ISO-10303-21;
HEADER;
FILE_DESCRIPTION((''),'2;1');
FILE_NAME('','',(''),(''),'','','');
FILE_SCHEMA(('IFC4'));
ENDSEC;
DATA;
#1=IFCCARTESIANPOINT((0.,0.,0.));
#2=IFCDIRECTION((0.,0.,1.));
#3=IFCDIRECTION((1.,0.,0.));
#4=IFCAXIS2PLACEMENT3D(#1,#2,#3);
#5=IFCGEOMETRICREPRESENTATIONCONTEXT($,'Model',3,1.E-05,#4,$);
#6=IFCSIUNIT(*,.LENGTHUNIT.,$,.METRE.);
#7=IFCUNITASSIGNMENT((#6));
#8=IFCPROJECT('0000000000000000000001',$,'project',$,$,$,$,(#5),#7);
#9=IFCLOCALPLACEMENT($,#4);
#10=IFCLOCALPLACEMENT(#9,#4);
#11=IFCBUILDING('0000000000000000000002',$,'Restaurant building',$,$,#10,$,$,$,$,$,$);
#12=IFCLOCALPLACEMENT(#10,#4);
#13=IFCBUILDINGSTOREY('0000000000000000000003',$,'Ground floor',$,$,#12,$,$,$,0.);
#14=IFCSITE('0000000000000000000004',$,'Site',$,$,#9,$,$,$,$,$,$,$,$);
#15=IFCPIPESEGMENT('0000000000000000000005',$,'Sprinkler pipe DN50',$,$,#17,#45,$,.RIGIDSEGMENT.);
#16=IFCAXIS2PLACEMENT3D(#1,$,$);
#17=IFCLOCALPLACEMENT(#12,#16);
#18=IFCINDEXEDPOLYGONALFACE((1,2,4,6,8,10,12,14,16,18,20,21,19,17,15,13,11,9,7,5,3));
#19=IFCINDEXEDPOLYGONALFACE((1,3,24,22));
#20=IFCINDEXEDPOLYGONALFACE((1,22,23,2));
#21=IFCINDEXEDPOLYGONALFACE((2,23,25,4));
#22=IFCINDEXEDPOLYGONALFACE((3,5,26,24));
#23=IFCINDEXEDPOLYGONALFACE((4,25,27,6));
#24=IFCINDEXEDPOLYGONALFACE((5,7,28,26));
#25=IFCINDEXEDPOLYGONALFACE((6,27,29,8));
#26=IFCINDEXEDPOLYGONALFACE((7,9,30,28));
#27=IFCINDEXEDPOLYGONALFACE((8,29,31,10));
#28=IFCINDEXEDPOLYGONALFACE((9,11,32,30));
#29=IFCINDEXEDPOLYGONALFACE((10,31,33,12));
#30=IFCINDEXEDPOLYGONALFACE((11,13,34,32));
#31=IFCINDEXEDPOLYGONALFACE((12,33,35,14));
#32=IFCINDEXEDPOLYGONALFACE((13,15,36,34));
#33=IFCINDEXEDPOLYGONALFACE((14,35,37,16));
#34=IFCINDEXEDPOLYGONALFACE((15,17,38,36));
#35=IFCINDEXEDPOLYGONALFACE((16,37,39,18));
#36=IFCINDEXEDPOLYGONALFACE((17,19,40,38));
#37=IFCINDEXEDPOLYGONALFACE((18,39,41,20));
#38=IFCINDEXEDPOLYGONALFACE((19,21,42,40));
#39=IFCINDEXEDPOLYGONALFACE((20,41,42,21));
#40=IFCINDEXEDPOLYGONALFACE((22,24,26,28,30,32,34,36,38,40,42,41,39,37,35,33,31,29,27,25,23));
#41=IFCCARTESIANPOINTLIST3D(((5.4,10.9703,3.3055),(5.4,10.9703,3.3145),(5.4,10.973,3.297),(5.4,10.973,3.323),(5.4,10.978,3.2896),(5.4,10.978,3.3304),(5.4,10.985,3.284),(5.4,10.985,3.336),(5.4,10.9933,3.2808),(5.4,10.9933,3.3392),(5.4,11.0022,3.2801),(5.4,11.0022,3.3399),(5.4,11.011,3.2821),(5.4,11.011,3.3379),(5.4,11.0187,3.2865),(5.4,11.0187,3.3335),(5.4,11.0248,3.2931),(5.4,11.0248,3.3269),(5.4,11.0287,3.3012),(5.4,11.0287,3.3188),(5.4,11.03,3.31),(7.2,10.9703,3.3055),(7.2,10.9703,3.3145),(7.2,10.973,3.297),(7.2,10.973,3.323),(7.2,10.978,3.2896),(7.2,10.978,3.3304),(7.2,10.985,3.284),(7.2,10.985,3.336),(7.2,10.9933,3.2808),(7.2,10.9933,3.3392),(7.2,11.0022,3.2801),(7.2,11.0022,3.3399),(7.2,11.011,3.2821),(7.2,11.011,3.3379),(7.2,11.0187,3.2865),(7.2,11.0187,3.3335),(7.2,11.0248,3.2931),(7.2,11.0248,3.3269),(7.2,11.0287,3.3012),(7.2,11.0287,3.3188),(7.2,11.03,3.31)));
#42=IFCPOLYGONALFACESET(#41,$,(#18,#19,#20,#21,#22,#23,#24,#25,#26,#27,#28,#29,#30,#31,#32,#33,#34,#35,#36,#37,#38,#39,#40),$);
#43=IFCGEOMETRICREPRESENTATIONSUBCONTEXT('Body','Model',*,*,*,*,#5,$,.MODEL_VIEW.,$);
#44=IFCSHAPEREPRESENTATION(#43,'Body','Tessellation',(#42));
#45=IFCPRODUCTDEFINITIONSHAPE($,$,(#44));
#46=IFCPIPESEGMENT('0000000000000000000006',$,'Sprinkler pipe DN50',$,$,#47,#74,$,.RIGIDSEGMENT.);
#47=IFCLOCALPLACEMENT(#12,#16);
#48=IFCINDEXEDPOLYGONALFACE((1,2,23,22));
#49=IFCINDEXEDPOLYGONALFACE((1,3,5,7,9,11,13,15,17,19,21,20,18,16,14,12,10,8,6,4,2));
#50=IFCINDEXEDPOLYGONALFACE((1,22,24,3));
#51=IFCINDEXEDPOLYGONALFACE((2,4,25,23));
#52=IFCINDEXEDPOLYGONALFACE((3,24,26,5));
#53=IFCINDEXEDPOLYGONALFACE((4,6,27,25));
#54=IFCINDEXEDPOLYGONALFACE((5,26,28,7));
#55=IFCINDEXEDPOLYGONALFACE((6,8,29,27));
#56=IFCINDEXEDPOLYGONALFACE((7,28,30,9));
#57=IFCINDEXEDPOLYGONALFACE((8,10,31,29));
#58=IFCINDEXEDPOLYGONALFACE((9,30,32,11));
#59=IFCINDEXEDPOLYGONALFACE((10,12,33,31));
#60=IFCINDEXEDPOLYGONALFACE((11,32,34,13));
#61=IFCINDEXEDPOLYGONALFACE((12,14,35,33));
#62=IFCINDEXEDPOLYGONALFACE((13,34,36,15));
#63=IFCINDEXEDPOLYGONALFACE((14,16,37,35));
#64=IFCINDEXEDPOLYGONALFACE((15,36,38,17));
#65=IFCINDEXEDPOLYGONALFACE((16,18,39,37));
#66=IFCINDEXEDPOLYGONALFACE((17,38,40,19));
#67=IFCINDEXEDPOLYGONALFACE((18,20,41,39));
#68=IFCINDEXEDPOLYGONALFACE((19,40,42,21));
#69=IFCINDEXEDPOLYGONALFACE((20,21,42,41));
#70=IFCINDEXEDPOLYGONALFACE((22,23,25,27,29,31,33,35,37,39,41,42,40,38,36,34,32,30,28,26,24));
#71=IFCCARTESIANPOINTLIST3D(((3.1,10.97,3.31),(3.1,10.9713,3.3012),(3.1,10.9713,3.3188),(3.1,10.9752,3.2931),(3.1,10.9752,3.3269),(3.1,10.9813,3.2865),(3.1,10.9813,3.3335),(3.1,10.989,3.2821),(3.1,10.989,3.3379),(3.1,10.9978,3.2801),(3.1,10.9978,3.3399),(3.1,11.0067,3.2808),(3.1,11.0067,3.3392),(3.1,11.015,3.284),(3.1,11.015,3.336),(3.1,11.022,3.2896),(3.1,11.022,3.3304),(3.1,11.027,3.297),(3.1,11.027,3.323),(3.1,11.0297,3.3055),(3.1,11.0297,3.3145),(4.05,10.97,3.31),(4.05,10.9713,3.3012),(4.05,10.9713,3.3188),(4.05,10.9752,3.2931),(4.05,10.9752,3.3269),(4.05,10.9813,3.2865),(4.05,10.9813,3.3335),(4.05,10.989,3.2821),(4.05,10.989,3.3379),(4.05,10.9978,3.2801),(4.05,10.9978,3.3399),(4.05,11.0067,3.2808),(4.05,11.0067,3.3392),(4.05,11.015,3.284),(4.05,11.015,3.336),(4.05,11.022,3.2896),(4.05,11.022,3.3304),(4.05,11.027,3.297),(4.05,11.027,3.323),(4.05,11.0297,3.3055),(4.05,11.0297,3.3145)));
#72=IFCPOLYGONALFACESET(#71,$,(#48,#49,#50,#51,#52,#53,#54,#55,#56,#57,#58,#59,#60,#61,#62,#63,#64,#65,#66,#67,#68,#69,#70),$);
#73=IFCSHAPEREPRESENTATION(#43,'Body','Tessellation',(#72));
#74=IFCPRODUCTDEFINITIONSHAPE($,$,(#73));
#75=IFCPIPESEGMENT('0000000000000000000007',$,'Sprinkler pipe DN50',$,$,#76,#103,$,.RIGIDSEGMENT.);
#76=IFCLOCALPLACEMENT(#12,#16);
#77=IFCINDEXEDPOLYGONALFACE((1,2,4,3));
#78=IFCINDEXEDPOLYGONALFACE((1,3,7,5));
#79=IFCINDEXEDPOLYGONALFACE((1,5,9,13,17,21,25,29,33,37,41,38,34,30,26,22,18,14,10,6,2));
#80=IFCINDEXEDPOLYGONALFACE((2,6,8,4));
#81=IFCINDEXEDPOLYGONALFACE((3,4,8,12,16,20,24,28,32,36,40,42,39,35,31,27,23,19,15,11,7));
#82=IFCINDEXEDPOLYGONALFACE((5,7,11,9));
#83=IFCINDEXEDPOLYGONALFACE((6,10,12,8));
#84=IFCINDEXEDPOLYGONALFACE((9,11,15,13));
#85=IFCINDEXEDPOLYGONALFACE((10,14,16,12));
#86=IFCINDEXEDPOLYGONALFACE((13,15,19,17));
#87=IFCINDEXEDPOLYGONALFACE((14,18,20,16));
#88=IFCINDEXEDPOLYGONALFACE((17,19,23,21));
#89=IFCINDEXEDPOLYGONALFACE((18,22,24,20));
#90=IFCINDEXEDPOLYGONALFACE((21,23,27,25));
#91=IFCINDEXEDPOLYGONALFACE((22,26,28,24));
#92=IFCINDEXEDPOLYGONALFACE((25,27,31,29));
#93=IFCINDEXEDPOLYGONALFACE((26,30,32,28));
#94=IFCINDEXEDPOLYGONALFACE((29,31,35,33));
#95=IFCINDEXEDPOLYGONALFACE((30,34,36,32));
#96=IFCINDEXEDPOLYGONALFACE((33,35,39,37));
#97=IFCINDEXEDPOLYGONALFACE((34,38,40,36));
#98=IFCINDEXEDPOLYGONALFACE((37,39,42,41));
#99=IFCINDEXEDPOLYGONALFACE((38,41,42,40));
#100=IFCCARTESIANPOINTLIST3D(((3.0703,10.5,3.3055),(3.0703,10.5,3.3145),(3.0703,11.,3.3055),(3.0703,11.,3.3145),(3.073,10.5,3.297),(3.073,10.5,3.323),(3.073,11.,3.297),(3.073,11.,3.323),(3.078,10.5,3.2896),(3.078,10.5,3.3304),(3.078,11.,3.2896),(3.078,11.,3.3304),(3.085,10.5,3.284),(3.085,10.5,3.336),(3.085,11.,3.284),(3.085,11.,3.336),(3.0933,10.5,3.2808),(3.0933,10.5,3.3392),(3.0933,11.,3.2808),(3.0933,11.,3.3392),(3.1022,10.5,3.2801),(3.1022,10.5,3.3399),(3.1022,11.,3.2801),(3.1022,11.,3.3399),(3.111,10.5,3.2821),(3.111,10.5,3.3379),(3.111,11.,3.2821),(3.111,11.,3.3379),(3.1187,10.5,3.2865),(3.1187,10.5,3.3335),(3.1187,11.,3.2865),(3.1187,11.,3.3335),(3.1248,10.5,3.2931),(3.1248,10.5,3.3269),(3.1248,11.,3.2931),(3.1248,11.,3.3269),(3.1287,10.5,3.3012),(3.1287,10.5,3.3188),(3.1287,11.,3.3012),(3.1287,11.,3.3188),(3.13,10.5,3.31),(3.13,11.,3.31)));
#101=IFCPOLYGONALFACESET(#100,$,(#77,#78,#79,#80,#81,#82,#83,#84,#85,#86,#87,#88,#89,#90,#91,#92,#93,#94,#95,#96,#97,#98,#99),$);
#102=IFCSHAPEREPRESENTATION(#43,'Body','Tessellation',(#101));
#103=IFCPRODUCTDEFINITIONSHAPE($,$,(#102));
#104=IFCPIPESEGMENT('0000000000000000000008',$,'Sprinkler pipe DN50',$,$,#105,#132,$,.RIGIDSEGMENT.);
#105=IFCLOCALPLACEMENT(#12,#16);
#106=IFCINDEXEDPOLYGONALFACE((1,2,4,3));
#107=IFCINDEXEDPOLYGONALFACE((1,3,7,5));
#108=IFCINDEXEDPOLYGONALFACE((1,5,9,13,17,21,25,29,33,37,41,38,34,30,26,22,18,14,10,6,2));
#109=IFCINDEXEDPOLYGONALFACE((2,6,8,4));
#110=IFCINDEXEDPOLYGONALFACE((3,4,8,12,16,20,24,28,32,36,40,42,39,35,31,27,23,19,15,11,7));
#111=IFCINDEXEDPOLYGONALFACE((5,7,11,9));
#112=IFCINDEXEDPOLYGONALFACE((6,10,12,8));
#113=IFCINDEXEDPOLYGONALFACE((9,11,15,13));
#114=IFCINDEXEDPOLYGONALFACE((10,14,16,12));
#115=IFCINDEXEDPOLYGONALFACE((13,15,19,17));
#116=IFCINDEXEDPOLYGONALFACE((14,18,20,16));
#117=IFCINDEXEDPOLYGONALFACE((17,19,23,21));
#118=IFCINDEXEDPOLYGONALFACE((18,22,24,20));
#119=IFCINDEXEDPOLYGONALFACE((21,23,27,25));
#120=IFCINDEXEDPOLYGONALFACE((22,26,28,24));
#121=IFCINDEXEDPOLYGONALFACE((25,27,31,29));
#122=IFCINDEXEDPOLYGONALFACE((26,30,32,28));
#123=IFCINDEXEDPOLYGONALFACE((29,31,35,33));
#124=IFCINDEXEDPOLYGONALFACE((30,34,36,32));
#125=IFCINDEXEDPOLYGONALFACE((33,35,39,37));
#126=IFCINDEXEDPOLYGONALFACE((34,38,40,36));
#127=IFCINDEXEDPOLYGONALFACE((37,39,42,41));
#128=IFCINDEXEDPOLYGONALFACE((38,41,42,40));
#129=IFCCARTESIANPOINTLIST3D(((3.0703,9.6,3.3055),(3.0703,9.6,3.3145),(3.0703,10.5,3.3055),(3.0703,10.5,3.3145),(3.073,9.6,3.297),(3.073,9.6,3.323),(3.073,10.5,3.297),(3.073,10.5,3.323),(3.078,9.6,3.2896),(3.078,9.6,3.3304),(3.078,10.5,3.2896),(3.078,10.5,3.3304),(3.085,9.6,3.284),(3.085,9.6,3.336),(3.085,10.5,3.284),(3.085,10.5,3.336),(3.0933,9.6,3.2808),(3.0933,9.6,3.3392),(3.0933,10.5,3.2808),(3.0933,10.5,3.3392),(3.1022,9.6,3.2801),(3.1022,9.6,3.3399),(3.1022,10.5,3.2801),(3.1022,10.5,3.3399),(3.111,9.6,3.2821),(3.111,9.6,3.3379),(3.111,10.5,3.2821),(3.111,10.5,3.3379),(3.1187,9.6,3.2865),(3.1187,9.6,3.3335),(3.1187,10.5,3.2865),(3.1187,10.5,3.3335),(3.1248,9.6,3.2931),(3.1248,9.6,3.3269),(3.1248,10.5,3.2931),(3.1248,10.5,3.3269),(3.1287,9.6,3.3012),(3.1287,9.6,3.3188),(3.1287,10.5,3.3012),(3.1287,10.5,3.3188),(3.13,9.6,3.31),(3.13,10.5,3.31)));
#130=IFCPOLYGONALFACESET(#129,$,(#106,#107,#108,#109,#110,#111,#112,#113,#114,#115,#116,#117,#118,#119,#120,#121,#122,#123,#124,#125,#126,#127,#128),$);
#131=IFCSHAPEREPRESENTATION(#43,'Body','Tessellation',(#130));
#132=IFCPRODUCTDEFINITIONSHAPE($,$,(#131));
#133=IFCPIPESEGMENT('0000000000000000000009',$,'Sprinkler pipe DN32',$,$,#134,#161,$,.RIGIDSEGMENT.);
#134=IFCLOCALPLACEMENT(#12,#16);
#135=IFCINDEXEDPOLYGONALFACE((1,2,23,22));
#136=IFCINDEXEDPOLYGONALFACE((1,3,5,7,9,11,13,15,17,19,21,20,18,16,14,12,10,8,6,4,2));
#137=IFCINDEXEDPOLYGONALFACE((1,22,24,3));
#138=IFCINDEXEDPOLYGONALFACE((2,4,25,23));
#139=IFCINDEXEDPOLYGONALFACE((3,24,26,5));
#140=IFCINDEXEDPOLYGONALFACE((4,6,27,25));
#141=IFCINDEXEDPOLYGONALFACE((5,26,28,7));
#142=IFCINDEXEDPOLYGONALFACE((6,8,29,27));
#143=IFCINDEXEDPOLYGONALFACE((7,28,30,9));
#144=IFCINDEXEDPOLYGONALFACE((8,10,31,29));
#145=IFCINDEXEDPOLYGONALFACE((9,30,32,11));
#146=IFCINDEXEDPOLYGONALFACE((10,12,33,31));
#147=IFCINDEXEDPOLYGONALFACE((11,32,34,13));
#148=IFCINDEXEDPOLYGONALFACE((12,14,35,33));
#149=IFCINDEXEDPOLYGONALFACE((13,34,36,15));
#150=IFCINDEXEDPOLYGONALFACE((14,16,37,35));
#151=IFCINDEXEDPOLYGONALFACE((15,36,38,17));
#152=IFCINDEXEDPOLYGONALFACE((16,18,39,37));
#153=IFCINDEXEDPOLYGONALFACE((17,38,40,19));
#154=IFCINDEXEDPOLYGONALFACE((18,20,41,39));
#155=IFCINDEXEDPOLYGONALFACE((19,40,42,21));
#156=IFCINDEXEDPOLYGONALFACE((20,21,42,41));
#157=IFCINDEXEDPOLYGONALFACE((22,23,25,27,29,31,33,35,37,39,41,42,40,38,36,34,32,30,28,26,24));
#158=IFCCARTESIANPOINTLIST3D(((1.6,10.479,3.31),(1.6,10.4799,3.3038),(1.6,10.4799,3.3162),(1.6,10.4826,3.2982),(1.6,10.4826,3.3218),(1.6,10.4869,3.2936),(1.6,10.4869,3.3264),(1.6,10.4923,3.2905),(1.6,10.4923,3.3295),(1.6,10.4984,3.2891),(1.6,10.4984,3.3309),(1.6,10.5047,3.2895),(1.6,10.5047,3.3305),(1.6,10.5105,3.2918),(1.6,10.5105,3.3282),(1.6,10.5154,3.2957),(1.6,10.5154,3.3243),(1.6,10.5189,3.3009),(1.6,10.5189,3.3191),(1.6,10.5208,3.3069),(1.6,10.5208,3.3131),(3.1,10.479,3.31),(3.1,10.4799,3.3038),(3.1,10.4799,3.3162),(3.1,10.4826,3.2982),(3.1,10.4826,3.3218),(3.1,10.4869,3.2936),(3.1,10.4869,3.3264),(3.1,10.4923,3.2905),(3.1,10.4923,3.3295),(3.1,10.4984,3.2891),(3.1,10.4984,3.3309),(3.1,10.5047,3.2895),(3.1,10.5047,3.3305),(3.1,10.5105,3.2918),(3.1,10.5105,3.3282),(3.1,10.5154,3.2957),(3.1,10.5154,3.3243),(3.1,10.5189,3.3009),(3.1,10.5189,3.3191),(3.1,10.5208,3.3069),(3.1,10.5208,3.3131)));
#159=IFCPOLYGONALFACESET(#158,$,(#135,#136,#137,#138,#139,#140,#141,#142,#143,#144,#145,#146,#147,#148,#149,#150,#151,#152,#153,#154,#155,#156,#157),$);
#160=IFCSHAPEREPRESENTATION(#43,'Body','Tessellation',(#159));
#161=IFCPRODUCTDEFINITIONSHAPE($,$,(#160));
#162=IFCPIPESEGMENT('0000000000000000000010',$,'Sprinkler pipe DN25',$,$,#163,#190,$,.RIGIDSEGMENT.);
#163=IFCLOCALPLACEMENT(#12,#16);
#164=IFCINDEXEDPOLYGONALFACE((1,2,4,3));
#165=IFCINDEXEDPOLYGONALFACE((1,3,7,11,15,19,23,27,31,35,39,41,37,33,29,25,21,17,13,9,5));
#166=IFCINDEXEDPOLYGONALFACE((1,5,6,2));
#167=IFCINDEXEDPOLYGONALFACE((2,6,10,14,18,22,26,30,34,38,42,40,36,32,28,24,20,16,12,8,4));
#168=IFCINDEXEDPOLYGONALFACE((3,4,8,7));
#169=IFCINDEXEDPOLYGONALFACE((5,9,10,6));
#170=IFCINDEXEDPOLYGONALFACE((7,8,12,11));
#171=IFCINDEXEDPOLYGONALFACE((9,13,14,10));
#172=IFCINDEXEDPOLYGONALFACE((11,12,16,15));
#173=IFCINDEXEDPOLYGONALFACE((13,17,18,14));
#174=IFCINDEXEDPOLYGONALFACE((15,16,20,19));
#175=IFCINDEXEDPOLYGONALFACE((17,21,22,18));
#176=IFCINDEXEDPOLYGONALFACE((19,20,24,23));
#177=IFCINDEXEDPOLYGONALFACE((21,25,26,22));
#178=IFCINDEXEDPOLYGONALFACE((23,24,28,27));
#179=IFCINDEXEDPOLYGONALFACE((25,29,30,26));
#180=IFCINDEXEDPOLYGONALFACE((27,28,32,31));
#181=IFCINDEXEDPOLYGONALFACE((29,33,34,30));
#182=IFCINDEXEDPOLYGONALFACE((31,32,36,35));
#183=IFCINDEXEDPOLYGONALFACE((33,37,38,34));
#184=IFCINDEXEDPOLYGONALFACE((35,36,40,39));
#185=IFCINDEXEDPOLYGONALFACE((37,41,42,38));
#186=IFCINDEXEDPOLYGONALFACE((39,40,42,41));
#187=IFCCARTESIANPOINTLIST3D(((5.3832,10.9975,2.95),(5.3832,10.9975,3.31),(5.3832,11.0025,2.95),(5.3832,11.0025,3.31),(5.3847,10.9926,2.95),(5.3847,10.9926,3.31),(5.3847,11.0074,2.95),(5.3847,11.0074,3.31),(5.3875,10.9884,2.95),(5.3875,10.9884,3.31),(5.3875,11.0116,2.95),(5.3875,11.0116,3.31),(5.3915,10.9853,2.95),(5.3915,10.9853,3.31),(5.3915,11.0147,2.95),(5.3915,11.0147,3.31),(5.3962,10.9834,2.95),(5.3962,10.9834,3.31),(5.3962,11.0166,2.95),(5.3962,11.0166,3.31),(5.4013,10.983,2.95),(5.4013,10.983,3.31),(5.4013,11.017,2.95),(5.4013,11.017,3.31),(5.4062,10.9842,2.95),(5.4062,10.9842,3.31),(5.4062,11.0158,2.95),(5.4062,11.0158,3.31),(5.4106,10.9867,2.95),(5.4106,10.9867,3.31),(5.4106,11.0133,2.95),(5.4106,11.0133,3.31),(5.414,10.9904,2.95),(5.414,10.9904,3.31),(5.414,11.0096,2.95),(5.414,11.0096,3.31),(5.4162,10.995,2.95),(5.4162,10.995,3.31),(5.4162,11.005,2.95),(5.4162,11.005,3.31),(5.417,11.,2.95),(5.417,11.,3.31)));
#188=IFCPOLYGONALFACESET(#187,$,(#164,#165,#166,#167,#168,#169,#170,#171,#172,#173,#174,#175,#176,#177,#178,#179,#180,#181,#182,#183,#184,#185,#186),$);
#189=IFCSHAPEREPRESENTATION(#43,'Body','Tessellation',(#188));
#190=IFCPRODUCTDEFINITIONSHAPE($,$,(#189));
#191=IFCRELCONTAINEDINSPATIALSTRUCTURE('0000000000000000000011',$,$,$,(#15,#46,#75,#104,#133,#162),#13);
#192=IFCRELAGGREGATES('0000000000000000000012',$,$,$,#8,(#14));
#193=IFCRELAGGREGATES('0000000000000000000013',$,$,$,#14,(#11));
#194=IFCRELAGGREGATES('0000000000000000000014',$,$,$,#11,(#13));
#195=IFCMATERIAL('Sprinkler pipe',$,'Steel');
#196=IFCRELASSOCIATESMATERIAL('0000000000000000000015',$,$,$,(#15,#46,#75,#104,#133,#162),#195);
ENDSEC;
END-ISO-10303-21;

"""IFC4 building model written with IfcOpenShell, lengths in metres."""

from ifc_helpers import new_model, si_unit, frame, origin_with_axes, origin_2d, place, context, subcontext, project, spatial, circle, extrude, material, element, save


model = new_model("IFC4")

# Units and contexts
model_context = context("Model", 3, precision=1e-05, world=origin_with_axes())
body_context = subcontext(model_context, "Body", "Model", "MODEL_VIEW")
ifc_project = project(units=[si_unit("LENGTHUNIT", "METRE")], contexts=[model_context])

# Site, building, storey
site_placement = place(None, origin_with_axes())
site = spatial("IfcSite", under=ifc_project, at=site_placement, Name="Site")
building_placement = place(site_placement, origin_with_axes())
building = spatial("IfcBuilding", under=site, at=building_placement, Name="Restaurant building")
storey_placement = place(building_placement, origin_with_axes())
storey = spatial("IfcBuildingStorey", under=building, at=storey_placement, Name="Ground floor", Elevation=0.0)

# Pipe segments
ifc_material_1 = material(Name="Sprinkler pipe", Category="Steel")
pipe_segment_1_placement = place(storey_placement, frame((5.4, 11.0, 3.31)))
element("IfcPipeSegment", 1, at=pipe_segment_1_placement, inside=storey, material=ifc_material_1, Name="Sprinkler pipe DN50", PredefinedType="RIGIDSEGMENT", context=body_context, shape_type="SweptSolid", body=[
    extrude(circle(Radius=0.03, at=origin_2d()), frame((0.0, 0.0, 0.0), z_axis=(1.0, 0.0, 0.0), x_axis=(0.0, 1.0, 0.0)), (0.0, 0.0, 1.0), 1.8),
])
pipe_segment_2_placement = place(storey_placement, frame((4.05, 11.0, 3.31)))
element("IfcPipeSegment", 2, at=pipe_segment_2_placement, inside=storey, material=ifc_material_1, Name="Sprinkler pipe DN50", PredefinedType="RIGIDSEGMENT", context=body_context, shape_type="SweptSolid", body=[
    extrude(circle(Radius=0.03, at=origin_2d()), frame((0.0, 0.0, 0.0), z_axis=(-1.0, 0.0, 0.0), x_axis=(0.0, -1.0, 0.0)), (0.0, 0.0, 1.0), 0.95),
])
pipe_segment_3_placement = place(storey_placement, frame((3.1, 11.0, 3.31)))
element("IfcPipeSegment", 3, at=pipe_segment_3_placement, inside=storey, material=ifc_material_1, Name="Sprinkler pipe DN50", PredefinedType="RIGIDSEGMENT", context=body_context, shape_type="SweptSolid", body=[
    extrude(circle(Radius=0.03, at=origin_2d()), frame((0.0, 0.0, 0.0), z_axis=(0.0, -1.0, 0.0), x_axis=(1.0, 0.0, 0.0)), (0.0, 0.0, 1.0), 0.5),
])
pipe_segment_4_placement = place(storey_placement, frame((3.1, 10.5, 3.31)))
element("IfcPipeSegment", 4, at=pipe_segment_4_placement, inside=storey, material=ifc_material_1, Name="Sprinkler pipe DN50", PredefinedType="RIGIDSEGMENT", context=body_context, shape_type="SweptSolid", body=[
    extrude(circle(Radius=0.03, at=origin_2d()), frame((0.0, 0.0, 0.0), z_axis=(0.0, -1.0, 0.0), x_axis=(1.0, 0.0, 0.0)), (0.0, 0.0, 1.0), 0.9),
])
pipe_segment_5_placement = place(storey_placement, frame((3.1, 10.5, 3.31)))
element("IfcPipeSegment", 5, at=pipe_segment_5_placement, inside=storey, material=ifc_material_1, Name="Sprinkler pipe DN32", PredefinedType="RIGIDSEGMENT", context=body_context, shape_type="SweptSolid", body=[
    extrude(circle(Radius=0.021, at=origin_2d()), frame((0.0, 0.0, 0.0), z_axis=(-1.0, 0.0, 0.0), x_axis=(0.0, -1.0, 0.0)), (0.0, 0.0, 1.0), 1.5),
])
pipe_segment_6_placement = place(storey_placement, frame((5.4, 11.0, 3.31)))
element("IfcPipeSegment", 6, at=pipe_segment_6_placement, inside=storey, material=ifc_material_1, Name="Sprinkler pipe DN25", PredefinedType="RIGIDSEGMENT", context=body_context, shape_type="SweptSolid", body=[
    extrude(circle(Radius=0.017, at=origin_2d()), frame((0.0, 0.0, 0.0), z_axis=(0.0, 0.0, -1.0), x_axis=(1.0, 0.0, 0.0)), (0.0, 0.0, 1.0), 0.36),
])

save(model, "model.ifc")
